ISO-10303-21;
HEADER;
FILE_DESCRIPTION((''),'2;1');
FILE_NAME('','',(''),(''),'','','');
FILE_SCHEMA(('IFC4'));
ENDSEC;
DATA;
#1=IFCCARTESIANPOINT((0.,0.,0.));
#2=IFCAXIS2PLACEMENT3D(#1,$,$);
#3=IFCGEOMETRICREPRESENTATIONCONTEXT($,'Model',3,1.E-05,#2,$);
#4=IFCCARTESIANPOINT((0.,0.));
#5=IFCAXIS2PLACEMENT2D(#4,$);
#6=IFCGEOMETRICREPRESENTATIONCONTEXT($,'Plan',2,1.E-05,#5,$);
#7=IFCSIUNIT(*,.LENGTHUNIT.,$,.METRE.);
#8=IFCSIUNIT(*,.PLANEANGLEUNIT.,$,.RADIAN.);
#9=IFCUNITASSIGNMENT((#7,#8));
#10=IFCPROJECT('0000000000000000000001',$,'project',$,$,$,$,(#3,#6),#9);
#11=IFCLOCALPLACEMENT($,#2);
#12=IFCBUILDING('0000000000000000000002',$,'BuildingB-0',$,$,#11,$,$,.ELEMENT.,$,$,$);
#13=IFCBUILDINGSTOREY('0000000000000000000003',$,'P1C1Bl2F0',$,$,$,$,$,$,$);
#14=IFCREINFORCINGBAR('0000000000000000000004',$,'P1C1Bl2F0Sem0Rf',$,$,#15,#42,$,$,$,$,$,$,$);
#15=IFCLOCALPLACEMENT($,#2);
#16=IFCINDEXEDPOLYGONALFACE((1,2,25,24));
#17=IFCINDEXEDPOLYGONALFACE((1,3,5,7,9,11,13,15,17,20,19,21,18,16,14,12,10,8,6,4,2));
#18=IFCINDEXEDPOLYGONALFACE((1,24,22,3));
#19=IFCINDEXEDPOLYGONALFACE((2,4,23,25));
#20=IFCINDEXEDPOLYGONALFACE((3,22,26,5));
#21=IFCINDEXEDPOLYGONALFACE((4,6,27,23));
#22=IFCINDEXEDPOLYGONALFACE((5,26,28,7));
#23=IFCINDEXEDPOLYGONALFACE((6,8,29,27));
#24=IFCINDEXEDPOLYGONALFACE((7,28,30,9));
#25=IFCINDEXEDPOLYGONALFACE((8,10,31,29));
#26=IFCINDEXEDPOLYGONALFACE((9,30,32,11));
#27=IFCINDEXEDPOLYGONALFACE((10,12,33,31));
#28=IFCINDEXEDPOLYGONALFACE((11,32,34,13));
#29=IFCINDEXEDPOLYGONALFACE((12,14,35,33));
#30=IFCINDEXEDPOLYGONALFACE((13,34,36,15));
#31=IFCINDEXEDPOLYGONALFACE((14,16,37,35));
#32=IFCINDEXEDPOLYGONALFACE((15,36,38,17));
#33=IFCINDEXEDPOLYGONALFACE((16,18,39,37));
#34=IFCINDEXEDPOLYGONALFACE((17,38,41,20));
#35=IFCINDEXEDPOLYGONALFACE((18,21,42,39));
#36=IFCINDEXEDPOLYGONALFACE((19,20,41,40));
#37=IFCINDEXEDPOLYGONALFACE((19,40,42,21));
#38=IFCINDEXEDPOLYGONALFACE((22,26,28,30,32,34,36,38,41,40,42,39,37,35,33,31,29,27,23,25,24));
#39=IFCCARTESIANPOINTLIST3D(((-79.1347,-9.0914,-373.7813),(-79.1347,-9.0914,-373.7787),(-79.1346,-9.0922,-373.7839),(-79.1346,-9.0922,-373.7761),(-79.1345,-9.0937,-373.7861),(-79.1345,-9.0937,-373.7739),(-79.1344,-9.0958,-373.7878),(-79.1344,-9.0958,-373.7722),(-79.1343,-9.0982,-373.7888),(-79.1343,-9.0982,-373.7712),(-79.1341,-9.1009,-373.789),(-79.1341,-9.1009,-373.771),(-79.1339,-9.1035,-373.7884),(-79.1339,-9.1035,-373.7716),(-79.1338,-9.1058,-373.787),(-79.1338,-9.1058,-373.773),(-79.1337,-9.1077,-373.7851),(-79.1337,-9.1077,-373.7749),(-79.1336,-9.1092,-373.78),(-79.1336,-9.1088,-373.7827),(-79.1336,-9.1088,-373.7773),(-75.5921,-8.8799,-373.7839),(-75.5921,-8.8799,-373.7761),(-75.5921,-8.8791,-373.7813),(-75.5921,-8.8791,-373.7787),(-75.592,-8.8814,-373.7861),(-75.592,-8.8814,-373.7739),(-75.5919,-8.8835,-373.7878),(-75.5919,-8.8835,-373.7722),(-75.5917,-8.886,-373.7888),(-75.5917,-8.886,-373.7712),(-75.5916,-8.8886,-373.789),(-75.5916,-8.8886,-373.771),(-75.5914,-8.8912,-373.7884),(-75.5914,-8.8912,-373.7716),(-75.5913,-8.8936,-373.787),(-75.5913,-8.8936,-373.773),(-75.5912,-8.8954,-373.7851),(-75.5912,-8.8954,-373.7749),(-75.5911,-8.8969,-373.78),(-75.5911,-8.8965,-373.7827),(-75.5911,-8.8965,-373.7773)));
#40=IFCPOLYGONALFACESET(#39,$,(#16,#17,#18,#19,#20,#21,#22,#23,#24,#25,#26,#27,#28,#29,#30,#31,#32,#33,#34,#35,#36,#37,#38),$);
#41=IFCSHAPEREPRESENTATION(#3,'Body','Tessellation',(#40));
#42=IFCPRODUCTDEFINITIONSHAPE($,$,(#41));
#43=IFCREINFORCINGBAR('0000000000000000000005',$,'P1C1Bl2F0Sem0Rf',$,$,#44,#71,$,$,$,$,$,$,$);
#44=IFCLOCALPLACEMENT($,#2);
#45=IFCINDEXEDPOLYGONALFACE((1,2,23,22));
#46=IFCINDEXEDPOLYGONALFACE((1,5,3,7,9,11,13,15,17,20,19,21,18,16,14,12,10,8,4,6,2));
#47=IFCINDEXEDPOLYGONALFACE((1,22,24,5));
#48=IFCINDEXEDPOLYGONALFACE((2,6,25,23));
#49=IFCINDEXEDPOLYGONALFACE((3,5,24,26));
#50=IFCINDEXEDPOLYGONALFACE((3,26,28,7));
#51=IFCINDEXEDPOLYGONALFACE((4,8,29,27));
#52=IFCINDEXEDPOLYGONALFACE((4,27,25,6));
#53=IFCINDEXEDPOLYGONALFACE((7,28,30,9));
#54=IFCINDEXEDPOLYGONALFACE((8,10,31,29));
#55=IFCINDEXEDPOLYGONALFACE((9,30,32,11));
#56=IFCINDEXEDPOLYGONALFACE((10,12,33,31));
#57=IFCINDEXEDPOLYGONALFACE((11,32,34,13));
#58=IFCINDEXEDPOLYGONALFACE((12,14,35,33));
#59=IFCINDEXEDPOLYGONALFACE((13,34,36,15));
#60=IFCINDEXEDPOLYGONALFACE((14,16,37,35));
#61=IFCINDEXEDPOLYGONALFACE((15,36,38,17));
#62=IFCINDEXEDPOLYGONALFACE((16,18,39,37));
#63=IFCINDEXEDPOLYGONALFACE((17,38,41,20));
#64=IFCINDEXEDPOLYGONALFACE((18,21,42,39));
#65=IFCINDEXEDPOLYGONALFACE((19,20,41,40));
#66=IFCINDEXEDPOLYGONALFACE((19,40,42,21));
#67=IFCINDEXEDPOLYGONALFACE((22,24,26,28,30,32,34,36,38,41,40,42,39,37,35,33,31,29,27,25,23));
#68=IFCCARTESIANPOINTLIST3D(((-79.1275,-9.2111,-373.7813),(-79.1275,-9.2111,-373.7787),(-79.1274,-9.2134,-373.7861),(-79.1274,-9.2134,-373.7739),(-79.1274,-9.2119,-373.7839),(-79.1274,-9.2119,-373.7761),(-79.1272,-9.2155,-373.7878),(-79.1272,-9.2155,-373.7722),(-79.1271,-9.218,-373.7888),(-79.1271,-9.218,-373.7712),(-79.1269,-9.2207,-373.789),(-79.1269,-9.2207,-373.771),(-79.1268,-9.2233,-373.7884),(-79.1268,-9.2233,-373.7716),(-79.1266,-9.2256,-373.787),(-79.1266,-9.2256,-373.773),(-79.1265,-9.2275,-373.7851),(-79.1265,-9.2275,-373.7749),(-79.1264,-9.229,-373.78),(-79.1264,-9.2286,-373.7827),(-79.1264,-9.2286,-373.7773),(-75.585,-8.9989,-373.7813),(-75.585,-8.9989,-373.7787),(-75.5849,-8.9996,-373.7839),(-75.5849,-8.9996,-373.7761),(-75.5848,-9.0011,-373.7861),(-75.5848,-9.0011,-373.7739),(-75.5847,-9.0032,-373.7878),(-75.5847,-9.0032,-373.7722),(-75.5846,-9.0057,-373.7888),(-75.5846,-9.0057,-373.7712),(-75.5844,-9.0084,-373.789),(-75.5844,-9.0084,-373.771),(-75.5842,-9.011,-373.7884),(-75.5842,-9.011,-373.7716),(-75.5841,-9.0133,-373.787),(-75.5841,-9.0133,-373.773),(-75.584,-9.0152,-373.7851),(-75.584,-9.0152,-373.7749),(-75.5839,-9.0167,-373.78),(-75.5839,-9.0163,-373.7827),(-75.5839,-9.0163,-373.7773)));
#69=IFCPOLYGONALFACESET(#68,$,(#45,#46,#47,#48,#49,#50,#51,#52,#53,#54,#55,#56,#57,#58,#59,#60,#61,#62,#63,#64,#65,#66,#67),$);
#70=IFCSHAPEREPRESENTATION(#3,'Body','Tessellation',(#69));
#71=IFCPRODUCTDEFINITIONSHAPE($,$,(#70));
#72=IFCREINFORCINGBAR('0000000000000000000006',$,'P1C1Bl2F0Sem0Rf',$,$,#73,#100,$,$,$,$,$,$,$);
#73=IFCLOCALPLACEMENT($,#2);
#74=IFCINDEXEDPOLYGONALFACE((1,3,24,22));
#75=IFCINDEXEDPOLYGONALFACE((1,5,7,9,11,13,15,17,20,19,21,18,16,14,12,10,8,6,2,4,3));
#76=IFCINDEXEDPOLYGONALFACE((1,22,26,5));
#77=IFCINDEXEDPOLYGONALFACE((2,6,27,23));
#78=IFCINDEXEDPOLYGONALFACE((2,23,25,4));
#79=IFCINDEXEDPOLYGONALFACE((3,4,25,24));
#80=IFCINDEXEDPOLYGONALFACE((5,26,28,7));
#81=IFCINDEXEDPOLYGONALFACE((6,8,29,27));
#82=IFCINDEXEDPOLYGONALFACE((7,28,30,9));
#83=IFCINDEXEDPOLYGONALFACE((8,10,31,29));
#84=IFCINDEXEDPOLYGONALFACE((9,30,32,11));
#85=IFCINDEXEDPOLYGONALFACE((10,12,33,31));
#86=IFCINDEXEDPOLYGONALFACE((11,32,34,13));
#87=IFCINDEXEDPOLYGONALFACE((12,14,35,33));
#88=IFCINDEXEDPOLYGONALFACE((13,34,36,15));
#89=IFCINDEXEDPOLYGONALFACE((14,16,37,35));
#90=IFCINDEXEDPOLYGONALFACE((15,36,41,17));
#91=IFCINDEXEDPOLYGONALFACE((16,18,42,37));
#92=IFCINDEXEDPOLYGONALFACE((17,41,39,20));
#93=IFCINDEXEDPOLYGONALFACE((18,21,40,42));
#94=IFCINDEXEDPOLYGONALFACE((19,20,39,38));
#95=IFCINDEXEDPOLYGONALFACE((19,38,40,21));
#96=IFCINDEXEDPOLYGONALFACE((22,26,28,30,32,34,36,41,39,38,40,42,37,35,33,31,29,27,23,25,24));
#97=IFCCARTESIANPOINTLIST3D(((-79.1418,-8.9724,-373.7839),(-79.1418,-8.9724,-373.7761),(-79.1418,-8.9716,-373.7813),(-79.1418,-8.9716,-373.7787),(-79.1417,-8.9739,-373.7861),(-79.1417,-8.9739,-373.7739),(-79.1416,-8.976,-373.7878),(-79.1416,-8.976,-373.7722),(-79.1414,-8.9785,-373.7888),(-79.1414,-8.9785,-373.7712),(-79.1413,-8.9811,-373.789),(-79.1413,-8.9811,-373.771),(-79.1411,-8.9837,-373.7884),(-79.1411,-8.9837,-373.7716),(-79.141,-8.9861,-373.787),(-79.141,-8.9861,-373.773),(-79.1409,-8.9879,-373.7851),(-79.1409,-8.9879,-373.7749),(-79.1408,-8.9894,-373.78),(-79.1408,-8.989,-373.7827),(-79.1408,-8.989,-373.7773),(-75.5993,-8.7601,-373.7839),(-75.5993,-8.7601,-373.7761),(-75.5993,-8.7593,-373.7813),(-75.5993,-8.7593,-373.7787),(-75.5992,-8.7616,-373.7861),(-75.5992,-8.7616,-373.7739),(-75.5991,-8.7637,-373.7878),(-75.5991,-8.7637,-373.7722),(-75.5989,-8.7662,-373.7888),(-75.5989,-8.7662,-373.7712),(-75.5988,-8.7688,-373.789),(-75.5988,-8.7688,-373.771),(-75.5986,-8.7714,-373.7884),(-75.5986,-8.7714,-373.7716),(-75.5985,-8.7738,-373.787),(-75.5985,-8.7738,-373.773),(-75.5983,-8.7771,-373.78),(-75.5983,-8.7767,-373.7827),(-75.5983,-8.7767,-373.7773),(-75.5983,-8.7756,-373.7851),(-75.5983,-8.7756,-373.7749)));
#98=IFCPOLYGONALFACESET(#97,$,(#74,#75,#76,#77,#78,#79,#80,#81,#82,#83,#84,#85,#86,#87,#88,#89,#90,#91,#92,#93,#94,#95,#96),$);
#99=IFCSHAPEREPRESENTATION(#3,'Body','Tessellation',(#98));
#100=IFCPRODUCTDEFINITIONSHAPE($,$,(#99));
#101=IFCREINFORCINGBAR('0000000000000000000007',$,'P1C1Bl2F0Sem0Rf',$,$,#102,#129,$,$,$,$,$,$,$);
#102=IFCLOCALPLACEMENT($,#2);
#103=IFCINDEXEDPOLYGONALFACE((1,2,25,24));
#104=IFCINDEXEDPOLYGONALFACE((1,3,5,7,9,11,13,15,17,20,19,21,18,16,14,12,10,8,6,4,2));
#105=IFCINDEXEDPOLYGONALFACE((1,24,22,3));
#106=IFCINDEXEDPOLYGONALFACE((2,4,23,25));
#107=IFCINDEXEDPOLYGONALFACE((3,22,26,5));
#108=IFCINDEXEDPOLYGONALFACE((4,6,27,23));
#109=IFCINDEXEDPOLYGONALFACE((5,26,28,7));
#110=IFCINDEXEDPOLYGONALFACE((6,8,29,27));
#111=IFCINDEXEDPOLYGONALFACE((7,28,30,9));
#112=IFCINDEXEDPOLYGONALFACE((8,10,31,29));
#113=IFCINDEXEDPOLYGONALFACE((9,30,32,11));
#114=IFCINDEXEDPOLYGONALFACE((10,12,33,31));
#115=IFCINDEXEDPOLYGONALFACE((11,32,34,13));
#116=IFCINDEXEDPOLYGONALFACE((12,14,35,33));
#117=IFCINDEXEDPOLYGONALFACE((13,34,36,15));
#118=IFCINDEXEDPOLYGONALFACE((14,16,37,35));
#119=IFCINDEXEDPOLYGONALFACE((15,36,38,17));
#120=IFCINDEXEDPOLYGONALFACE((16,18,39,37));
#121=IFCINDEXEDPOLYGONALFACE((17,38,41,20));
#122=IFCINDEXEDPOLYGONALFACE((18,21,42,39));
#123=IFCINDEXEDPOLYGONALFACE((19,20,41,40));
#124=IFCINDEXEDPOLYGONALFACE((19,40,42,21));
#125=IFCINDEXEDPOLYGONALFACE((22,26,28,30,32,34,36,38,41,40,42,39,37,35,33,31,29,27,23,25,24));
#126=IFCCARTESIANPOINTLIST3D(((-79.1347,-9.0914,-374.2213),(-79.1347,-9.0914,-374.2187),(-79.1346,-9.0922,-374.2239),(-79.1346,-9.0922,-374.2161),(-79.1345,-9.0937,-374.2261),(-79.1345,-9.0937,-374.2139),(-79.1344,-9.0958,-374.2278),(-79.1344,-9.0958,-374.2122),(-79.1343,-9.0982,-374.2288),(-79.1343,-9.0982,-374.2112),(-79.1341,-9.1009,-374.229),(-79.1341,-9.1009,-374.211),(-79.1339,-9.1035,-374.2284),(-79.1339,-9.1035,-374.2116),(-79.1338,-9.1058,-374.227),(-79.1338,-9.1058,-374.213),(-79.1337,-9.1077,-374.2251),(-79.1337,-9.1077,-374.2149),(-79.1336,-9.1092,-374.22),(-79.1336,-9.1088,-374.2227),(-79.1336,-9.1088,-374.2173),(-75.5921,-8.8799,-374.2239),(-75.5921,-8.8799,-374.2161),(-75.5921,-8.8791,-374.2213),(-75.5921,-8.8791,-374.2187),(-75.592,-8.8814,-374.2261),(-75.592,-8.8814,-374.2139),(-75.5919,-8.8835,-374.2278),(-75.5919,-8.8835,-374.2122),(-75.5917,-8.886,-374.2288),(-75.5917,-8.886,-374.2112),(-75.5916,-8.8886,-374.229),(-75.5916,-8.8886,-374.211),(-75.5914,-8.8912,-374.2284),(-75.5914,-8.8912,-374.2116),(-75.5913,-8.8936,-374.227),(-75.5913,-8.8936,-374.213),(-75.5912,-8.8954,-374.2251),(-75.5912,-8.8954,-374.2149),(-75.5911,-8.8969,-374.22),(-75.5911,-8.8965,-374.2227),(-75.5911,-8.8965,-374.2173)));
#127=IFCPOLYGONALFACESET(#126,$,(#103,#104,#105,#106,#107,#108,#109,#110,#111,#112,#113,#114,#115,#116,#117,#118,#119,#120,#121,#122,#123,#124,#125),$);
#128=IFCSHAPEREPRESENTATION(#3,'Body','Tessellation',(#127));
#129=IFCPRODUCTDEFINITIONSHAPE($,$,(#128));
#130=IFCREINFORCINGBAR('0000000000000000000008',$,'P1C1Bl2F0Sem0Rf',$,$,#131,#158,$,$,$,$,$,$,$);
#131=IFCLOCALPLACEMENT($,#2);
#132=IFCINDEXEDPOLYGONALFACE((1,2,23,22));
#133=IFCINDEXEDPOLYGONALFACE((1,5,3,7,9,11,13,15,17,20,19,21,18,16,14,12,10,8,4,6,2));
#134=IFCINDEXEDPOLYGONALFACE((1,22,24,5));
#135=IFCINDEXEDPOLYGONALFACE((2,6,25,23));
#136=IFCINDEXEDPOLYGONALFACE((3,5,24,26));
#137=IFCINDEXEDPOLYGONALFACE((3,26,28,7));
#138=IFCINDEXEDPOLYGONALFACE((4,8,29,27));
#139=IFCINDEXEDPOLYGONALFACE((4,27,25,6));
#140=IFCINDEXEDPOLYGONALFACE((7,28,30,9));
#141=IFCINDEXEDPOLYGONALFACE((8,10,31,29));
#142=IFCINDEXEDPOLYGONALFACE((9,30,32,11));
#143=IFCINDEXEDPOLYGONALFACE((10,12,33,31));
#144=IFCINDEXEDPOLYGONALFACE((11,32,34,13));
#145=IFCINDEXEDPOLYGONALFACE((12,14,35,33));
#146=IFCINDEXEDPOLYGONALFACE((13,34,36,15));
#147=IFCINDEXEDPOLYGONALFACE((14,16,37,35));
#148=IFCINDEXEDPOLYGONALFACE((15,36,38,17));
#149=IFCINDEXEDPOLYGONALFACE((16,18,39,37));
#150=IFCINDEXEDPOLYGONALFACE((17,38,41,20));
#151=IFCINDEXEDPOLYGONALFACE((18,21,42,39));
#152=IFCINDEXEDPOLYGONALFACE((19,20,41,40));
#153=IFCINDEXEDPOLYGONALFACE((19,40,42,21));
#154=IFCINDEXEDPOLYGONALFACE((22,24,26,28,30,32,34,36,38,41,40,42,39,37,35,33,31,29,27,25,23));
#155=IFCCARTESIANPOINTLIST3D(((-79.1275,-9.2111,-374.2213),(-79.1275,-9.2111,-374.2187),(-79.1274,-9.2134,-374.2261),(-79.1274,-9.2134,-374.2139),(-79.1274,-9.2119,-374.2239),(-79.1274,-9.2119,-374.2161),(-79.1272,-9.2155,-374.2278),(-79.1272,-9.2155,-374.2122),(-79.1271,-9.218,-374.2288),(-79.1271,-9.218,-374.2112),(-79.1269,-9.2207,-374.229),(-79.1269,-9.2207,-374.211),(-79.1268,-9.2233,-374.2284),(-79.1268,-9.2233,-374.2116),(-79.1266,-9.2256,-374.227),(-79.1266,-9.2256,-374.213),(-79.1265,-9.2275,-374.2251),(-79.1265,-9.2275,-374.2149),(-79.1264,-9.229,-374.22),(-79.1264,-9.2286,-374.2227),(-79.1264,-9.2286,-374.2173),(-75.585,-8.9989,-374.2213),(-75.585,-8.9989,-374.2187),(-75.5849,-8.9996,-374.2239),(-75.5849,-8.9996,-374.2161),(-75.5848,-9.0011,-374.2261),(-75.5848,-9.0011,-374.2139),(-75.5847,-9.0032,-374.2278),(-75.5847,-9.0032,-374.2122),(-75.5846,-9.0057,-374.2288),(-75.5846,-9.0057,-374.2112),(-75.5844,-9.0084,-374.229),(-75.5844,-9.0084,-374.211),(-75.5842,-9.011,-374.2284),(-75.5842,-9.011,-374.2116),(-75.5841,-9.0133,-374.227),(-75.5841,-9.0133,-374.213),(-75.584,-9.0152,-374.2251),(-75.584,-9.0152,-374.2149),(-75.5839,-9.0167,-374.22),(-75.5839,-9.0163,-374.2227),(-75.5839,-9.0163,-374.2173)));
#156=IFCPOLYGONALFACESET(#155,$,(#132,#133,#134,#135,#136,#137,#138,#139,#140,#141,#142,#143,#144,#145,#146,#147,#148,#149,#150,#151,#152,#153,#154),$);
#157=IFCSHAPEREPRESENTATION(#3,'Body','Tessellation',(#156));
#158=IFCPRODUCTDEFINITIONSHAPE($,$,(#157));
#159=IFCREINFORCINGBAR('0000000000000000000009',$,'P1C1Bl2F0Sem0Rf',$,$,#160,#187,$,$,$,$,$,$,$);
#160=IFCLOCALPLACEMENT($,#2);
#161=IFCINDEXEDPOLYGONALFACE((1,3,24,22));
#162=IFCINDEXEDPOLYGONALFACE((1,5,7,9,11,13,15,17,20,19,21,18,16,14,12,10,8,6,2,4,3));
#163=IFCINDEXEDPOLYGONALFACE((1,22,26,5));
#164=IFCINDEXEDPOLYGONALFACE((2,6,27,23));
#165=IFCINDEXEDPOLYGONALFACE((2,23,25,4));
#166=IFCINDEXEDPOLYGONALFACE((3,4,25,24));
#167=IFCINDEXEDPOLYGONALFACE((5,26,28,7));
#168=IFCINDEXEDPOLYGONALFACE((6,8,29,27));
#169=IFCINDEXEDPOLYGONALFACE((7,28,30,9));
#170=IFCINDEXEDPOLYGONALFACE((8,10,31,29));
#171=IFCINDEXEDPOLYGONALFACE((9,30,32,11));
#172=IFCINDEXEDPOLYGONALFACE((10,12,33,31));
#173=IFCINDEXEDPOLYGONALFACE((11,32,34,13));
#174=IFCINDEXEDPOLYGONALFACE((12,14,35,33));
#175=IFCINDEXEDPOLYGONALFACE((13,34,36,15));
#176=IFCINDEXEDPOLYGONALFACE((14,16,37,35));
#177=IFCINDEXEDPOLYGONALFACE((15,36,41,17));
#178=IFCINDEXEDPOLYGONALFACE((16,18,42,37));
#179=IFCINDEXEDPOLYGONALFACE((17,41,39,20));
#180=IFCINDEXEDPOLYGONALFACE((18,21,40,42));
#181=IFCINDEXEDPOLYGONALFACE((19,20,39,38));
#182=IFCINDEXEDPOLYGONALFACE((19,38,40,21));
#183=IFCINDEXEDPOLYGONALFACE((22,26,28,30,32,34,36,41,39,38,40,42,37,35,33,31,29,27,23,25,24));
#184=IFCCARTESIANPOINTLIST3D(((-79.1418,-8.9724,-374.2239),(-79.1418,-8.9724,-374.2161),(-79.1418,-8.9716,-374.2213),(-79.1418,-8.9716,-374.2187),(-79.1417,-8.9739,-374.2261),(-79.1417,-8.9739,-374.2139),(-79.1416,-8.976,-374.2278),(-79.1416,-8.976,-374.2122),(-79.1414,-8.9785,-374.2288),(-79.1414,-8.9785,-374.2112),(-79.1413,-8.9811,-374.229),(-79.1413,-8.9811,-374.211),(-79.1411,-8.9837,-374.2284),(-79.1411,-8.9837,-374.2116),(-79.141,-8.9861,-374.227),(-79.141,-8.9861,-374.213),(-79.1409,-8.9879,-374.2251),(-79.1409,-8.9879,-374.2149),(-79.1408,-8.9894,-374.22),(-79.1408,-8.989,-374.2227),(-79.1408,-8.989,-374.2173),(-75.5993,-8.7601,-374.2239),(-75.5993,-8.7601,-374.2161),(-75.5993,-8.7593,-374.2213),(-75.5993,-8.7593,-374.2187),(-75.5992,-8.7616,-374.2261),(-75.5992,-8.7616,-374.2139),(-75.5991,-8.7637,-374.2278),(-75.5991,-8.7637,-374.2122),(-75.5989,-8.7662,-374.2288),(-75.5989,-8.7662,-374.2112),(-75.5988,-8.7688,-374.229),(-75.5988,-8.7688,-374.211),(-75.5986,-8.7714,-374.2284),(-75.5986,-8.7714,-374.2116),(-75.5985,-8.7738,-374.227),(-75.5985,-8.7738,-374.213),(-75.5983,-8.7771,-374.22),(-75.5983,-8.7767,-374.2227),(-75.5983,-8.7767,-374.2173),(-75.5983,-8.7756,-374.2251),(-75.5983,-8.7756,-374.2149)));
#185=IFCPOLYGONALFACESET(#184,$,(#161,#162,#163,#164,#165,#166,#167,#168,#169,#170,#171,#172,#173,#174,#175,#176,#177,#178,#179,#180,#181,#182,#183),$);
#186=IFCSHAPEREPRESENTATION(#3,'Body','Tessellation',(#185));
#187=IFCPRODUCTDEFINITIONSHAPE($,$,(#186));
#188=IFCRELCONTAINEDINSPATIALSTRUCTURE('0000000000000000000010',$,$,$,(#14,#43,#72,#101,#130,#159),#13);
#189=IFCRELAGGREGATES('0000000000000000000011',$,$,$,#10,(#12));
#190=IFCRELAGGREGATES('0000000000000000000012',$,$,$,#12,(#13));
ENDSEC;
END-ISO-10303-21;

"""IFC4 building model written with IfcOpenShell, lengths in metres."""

from ifc_helpers import new_model, entity, si_unit, origin, origin_2d, place, context, project, spatial, element, save


model = new_model("IFC4")

# Units and contexts
model_context = context("Model", 3, precision=1e-05, world=origin())
plan_context = context("Plan", 2, precision=1e-05, world=origin_2d())
ifc_project = project(units=[si_unit("LENGTHUNIT", "METRE"), si_unit("PLANEANGLEUNIT", "RADIAN")], contexts=[model_context, plan_context])

# Building, storey
building_placement = place(None, origin())
building = spatial("IfcBuilding", under=ifc_project, at=building_placement, Name="BuildingB-0", CompositionType="ELEMENT")
storey = spatial("IfcBuildingStorey", under=building, Name="P1C1Bl2F0")

# Reinforcing bars
element("IfcReinforcingBar", 1, inside=storey, Name="P1C1Bl2F0Sem0Rf", context=model_context, shape_type="SweptSolid", body=[
    entity("IfcSurfaceCurveSweptAreaSolid", entity("IfcCircleProfileDef", "AREA", None, None, 0.009), None, entity("IfcPolyline", [entity("IfcCartesianPoint", [79.1341, 9.1002, 373.78]), entity("IfcCartesianPoint", [75.5916, 8.888, 373.78])]), None, None, entity("IfcPlane", entity("IfcAxis2Placement3D", entity("IfcCartesianPoint", [79.1341, 9.1002, 373.78]), entity("IfcDirection", [0.0, 0.0, 1.0]), entity("IfcDirection", [1.0, 0.0, 0.0])))),
])
element("IfcReinforcingBar", 2, inside=storey, Name="P1C1Bl2F0Sem0Rf", context=model_context, shape_type="SweptSolid", body=[
    entity("IfcSurfaceCurveSweptAreaSolid", entity("IfcCircleProfileDef", "AREA", None, None, 0.009), None, entity("IfcPolyline", [entity("IfcCartesianPoint", [79.127, 9.22, 373.78]), entity("IfcCartesianPoint", [75.5844, 9.0077, 373.78])]), None, None, entity("IfcPlane", entity("IfcAxis2Placement3D", entity("IfcCartesianPoint", [79.127, 9.22, 373.78]), entity("IfcDirection", [0.0, 0.0, 1.0]), entity("IfcDirection", [1.0, 0.0, 0.0])))),
])
element("IfcReinforcingBar", 3, inside=storey, Name="P1C1Bl2F0Sem0Rf", context=model_context, shape_type="SweptSolid", body=[
    entity("IfcSurfaceCurveSweptAreaSolid", entity("IfcCircleProfileDef", "AREA", None, None, 0.009), None, entity("IfcPolyline", [entity("IfcCartesianPoint", [79.1413, 8.9805, 373.78]), entity("IfcCartesianPoint", [75.5988, 8.7682, 373.78])]), None, None, entity("IfcPlane", entity("IfcAxis2Placement3D", entity("IfcCartesianPoint", [79.1413, 8.9805, 373.78]), entity("IfcDirection", [0.0, 0.0, 1.0]), entity("IfcDirection", [1.0, 0.0, 0.0])))),
])
element("IfcReinforcingBar", 4, inside=storey, Name="P1C1Bl2F0Sem0Rf", context=model_context, shape_type="SweptSolid", body=[
    entity("IfcSurfaceCurveSweptAreaSolid", entity("IfcCircleProfileDef", "AREA", None, None, 0.009), None, entity("IfcPolyline", [entity("IfcCartesianPoint", [79.1341, 9.1002, 374.22]), entity("IfcCartesianPoint", [75.5916, 8.888, 374.22])]), None, None, entity("IfcPlane", entity("IfcAxis2Placement3D", entity("IfcCartesianPoint", [79.1341, 9.1002, 374.22]), entity("IfcDirection", [0.0, 0.0, 1.0]), entity("IfcDirection", [1.0, 0.0, 0.0])))),
])
element("IfcReinforcingBar", 5, inside=storey, Name="P1C1Bl2F0Sem0Rf", context=model_context, shape_type="SweptSolid", body=[
    entity("IfcSurfaceCurveSweptAreaSolid", entity("IfcCircleProfileDef", "AREA", None, None, 0.009), None, entity("IfcPolyline", [entity("IfcCartesianPoint", [79.127, 9.22, 374.22]), entity("IfcCartesianPoint", [75.5844, 9.0077, 374.22])]), None, None, entity("IfcPlane", entity("IfcAxis2Placement3D", entity("IfcCartesianPoint", [79.127, 9.22, 374.22]), entity("IfcDirection", [0.0, 0.0, 1.0]), entity("IfcDirection", [1.0, 0.0, 0.0])))),
])
element("IfcReinforcingBar", 6, inside=storey, Name="P1C1Bl2F0Sem0Rf", context=model_context, shape_type="SweptSolid", body=[
    entity("IfcSurfaceCurveSweptAreaSolid", entity("IfcCircleProfileDef", "AREA", None, None, 0.009), None, entity("IfcPolyline", [entity("IfcCartesianPoint", [79.1413, 8.9805, 374.22]), entity("IfcCartesianPoint", [75.5988, 8.7682, 374.22])]), None, None, entity("IfcPlane", entity("IfcAxis2Placement3D", entity("IfcCartesianPoint", [79.1413, 8.9805, 374.22]), entity("IfcDirection", [0.0, 0.0, 1.0]), entity("IfcDirection", [1.0, 0.0, 0.0])))),
])

save(model, "model.ifc")
